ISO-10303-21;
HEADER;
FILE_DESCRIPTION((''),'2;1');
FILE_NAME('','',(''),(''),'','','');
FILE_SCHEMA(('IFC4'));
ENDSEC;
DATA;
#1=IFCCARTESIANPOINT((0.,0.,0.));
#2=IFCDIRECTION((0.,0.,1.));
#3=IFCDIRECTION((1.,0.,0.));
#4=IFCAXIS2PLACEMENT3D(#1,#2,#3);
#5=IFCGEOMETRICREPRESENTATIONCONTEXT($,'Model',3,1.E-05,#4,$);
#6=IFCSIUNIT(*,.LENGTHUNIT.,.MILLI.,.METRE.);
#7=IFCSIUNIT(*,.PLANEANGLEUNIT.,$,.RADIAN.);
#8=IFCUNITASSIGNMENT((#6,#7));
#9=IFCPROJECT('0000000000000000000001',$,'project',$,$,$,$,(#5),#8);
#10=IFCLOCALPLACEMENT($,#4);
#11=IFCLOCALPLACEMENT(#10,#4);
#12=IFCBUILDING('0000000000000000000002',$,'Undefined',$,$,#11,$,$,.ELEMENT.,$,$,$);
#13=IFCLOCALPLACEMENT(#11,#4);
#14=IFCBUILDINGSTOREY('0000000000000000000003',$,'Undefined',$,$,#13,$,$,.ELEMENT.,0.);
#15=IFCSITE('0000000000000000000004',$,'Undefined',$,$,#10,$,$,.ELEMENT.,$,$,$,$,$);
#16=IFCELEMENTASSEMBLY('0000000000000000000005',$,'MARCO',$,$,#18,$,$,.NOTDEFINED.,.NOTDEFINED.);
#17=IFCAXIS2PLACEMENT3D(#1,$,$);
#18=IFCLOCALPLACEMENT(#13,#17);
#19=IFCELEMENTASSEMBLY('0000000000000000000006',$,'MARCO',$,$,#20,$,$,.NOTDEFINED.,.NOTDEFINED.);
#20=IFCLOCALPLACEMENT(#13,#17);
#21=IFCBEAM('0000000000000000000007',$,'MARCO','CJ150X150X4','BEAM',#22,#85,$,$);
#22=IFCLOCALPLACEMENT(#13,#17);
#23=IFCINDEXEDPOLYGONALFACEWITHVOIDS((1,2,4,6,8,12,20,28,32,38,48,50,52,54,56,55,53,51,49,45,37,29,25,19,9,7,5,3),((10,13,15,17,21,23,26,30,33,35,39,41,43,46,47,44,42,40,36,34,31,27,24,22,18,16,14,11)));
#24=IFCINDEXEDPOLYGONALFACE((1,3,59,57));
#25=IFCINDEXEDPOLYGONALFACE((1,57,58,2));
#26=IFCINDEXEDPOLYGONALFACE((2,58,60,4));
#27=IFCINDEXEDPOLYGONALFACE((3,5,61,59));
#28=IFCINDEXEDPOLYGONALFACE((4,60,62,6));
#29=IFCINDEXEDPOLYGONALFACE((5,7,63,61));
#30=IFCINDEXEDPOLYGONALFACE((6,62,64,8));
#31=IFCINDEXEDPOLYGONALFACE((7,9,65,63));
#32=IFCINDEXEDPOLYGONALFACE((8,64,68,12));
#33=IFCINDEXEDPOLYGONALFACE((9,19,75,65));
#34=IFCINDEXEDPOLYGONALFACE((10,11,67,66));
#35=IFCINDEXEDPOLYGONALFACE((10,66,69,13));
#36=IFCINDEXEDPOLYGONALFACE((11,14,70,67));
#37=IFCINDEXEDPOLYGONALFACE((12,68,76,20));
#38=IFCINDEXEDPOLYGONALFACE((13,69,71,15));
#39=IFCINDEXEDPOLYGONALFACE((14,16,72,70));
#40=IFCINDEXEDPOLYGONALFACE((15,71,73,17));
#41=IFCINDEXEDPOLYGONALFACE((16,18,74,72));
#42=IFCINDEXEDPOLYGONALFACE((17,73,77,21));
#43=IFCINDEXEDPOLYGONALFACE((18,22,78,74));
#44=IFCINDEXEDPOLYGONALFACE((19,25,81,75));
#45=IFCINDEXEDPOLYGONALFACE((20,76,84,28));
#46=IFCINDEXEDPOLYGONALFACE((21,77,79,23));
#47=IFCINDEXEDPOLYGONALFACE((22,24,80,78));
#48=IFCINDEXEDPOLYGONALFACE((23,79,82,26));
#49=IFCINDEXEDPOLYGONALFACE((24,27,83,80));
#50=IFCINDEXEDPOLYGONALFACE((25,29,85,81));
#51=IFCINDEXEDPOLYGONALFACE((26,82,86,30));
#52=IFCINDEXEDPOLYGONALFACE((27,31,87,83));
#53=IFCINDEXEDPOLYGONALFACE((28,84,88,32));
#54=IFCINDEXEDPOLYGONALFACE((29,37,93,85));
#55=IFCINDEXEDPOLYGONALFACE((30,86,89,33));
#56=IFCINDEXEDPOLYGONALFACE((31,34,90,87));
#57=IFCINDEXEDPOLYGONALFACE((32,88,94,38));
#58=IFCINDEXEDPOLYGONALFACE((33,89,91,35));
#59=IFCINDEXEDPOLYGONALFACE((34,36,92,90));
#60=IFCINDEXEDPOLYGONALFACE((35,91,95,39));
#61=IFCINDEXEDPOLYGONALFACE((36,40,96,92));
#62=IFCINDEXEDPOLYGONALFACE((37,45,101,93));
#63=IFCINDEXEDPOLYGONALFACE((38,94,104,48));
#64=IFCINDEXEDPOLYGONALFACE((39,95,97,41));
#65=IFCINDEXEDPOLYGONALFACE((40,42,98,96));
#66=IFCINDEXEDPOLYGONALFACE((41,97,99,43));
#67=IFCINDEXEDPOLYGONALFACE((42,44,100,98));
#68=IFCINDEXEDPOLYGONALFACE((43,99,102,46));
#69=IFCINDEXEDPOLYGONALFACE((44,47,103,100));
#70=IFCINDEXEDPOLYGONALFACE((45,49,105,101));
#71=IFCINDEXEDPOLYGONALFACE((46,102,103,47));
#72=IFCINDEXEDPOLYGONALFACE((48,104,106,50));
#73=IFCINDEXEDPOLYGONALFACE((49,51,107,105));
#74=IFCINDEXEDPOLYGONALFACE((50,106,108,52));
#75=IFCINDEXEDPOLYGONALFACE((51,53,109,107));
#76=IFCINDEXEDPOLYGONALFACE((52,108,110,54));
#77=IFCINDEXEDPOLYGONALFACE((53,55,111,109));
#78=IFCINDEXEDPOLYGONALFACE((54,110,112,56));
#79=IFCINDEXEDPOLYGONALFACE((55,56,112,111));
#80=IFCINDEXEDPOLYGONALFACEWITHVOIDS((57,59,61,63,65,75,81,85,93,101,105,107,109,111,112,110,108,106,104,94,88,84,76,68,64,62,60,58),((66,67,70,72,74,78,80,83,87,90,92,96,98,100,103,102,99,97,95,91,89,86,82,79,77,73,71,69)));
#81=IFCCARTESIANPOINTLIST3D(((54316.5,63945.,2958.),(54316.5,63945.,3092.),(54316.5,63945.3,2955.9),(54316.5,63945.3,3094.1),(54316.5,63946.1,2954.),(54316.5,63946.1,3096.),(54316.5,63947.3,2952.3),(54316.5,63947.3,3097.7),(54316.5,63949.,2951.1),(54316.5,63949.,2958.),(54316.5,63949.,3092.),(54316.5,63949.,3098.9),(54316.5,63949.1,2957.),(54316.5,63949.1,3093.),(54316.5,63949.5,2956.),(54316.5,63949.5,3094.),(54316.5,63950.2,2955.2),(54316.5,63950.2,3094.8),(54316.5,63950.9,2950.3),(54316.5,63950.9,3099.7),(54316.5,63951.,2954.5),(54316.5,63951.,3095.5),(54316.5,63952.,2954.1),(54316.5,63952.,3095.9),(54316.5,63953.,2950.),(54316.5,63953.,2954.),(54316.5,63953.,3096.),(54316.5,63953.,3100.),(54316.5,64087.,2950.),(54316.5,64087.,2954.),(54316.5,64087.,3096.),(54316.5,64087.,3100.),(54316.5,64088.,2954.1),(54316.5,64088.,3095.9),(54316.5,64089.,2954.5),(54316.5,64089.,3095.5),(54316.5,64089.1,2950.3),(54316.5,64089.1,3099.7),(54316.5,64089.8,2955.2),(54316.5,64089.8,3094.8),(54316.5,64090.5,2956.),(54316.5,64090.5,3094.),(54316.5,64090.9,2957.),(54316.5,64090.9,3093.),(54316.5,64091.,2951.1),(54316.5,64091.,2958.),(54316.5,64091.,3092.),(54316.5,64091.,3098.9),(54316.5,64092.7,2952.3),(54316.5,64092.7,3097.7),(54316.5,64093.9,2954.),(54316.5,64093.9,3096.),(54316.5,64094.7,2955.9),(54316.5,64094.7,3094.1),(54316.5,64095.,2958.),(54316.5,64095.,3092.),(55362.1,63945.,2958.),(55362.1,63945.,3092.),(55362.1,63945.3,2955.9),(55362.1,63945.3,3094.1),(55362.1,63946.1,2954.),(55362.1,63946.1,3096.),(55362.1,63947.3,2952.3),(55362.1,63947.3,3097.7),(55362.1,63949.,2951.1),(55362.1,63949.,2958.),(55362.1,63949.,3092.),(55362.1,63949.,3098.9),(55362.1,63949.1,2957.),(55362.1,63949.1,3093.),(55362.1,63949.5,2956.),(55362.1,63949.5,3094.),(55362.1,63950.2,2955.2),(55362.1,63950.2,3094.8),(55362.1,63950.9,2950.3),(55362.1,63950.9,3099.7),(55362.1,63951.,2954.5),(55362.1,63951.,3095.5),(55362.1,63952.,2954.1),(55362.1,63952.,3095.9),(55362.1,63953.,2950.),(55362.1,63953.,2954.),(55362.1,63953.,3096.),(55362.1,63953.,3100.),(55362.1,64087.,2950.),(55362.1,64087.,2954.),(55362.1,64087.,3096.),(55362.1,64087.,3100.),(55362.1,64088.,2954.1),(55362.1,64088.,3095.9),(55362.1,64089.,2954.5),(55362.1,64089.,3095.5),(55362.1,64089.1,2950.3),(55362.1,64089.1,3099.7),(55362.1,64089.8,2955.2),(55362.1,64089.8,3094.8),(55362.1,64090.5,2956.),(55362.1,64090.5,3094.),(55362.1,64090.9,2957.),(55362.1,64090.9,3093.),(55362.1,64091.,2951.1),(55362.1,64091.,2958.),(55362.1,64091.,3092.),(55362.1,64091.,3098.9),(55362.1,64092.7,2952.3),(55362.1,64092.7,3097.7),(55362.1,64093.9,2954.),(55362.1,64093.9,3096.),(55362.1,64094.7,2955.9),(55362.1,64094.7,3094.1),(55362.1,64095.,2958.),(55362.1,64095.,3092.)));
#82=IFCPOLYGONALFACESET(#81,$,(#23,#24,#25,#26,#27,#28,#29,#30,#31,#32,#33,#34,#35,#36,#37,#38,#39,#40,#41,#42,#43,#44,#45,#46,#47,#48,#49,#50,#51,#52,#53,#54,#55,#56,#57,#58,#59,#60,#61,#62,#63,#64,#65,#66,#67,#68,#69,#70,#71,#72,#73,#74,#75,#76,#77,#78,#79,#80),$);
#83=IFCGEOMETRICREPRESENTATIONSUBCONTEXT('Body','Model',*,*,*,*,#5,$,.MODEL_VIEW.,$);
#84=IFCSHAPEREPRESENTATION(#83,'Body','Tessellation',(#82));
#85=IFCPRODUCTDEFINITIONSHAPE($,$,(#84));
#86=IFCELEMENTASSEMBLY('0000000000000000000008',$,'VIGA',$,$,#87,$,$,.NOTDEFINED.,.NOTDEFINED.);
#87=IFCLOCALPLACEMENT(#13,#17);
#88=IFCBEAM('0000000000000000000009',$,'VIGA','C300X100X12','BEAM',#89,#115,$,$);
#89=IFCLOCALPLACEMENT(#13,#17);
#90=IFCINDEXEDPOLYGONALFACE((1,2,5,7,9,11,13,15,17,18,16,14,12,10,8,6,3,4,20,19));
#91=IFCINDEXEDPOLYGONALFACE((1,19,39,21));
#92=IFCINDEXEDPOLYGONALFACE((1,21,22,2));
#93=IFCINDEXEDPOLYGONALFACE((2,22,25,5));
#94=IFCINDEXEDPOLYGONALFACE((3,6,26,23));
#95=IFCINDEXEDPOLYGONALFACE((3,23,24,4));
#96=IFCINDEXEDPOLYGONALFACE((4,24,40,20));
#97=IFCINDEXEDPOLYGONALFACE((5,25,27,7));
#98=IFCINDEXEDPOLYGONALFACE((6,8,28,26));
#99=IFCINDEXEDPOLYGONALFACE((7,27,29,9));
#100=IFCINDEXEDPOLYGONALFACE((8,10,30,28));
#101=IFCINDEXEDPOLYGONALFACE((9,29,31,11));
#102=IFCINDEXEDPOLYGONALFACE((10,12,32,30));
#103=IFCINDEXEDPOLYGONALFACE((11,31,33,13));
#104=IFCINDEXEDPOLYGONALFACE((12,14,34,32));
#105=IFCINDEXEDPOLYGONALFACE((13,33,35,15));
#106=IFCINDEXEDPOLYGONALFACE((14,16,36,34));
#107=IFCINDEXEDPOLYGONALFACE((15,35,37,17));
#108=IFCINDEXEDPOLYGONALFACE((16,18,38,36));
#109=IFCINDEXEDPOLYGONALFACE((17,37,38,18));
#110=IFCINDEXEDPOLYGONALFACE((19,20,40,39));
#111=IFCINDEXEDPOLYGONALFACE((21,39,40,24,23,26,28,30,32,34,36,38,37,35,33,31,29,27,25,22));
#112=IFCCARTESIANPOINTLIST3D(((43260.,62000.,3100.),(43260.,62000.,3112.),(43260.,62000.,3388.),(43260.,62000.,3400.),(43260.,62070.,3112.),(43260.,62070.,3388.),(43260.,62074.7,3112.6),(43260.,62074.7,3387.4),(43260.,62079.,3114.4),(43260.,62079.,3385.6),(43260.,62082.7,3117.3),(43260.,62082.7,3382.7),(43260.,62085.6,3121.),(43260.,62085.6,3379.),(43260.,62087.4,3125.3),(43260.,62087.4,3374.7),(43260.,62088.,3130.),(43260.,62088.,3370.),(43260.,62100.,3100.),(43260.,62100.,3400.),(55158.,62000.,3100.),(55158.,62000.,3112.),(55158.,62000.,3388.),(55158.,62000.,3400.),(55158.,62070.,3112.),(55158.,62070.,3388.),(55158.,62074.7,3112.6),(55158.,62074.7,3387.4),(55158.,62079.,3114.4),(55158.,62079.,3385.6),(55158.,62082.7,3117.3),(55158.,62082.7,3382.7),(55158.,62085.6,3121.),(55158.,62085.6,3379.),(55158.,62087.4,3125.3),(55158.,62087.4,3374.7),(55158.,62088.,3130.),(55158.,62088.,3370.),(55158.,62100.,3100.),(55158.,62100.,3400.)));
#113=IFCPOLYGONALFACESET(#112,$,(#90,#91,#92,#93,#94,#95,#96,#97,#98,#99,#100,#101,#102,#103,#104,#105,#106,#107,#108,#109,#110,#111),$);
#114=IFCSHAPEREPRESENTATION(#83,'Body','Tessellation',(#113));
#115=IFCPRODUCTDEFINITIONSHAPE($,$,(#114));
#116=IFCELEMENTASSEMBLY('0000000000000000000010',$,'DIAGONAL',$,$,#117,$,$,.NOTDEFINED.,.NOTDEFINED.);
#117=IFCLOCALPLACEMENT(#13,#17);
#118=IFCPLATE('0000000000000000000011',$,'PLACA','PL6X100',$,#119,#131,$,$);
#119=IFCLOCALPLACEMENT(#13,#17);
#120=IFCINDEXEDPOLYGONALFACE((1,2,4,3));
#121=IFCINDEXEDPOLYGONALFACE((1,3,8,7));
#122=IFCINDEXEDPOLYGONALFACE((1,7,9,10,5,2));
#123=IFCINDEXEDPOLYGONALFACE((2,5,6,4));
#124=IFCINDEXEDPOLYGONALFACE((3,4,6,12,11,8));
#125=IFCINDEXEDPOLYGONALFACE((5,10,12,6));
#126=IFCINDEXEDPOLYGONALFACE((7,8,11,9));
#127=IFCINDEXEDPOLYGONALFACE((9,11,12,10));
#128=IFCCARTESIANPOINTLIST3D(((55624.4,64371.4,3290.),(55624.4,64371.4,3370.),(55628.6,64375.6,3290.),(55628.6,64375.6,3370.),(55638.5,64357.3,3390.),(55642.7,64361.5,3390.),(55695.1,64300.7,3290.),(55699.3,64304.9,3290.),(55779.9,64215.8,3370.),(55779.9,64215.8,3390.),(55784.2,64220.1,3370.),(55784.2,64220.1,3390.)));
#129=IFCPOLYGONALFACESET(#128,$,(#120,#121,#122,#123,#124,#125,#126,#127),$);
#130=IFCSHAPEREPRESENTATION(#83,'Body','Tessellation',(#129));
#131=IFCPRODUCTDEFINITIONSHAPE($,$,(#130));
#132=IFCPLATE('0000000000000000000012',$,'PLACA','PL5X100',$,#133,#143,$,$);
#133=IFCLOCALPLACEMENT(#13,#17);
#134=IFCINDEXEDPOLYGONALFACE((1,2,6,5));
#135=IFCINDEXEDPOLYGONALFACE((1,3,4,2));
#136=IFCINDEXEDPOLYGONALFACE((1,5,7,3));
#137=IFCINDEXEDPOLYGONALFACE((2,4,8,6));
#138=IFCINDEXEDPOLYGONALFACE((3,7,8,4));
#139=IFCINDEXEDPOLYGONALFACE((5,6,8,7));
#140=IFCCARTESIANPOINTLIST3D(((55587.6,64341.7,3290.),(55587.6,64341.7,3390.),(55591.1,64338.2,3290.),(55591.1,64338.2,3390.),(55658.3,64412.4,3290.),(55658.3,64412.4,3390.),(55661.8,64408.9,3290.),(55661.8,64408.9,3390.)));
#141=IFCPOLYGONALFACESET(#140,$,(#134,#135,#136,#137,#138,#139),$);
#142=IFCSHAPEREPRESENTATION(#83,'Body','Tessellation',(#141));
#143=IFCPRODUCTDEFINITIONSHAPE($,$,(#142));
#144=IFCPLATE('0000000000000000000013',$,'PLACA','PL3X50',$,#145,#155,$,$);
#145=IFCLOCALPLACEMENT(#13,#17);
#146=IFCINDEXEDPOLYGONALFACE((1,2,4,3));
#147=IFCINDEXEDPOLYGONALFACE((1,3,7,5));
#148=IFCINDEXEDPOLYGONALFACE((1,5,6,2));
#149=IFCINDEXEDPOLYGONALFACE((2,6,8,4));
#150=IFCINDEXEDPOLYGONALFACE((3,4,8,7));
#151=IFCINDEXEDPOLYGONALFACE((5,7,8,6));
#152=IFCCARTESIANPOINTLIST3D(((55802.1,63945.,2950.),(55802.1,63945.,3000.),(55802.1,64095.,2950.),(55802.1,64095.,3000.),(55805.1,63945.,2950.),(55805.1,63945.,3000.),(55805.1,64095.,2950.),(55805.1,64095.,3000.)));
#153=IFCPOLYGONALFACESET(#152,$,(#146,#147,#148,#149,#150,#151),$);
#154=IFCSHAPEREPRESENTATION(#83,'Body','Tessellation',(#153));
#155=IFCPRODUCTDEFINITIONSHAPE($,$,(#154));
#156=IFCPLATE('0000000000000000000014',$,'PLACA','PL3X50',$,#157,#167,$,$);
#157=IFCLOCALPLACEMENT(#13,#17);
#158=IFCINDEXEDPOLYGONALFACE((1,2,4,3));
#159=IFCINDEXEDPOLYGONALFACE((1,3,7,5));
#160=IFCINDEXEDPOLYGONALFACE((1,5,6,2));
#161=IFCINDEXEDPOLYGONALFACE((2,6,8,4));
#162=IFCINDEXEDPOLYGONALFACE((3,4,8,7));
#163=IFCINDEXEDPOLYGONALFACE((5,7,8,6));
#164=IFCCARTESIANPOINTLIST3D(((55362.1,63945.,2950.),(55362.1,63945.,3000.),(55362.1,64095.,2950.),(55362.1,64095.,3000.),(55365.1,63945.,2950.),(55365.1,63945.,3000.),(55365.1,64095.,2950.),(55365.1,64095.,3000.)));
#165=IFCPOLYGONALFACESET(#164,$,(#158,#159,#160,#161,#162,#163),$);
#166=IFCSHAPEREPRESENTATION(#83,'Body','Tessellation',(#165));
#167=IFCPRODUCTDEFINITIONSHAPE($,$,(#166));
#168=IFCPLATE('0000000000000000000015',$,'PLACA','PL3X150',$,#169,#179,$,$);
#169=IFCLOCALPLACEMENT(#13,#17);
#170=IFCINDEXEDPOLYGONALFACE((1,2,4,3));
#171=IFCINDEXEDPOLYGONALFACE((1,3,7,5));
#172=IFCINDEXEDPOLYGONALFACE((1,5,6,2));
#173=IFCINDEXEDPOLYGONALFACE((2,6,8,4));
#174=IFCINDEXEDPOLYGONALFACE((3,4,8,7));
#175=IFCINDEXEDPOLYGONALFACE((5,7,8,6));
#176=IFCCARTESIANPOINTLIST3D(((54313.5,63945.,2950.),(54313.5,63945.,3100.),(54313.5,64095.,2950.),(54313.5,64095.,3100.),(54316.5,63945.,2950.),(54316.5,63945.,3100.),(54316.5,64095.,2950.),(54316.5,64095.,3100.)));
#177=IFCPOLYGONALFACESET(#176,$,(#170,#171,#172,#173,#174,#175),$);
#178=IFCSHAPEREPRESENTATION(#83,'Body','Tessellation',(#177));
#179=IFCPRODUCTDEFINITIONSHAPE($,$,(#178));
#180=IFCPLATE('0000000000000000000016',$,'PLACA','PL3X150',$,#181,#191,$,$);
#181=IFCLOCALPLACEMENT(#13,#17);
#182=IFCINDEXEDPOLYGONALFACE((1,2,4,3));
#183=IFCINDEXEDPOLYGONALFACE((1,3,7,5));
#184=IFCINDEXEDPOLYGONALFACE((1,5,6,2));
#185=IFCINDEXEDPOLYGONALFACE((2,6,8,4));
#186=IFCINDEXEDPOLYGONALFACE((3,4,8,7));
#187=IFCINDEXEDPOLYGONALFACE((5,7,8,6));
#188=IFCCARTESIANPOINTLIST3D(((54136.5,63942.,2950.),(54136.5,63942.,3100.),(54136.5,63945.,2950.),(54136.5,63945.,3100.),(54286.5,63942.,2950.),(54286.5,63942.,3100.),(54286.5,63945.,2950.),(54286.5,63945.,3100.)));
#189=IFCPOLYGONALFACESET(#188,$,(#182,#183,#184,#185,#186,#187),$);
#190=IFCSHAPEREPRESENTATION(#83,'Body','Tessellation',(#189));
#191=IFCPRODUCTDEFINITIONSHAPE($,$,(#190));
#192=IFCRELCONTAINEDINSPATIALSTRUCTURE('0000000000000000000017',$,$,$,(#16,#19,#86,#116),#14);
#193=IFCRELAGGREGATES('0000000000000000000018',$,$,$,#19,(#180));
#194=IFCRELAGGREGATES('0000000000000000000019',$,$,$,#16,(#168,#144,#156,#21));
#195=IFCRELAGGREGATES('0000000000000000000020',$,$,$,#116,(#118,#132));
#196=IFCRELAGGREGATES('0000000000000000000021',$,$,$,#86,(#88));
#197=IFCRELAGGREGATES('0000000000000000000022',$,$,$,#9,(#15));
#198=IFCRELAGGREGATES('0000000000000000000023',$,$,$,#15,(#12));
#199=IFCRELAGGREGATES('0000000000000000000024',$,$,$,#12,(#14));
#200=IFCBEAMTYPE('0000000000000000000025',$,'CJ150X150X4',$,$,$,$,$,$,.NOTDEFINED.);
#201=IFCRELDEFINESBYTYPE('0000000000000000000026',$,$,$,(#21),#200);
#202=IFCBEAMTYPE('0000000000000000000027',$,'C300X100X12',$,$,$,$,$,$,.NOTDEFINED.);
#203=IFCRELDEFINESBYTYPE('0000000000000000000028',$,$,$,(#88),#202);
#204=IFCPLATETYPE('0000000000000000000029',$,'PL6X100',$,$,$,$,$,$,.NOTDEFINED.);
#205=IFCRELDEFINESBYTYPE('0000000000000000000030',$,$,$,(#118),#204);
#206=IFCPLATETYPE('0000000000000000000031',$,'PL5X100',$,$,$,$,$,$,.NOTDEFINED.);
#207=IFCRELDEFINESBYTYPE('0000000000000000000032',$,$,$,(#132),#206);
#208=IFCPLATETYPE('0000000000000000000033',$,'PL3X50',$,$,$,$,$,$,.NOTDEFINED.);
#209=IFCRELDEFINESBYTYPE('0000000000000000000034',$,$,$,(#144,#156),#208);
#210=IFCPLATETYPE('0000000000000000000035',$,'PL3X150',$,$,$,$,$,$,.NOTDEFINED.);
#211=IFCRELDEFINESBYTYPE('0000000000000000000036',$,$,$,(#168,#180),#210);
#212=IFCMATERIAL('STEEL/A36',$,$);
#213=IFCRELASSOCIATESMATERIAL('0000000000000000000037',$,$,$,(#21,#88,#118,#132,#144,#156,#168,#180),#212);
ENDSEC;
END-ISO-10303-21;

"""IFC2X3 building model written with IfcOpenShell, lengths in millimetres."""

from ifc_helpers import new_model, si_unit, frame, origin_with_axes, origin_2d_with_axis, place, context, subcontext, project, spatial, polyline, hollow_rectangle, u_section, outline, extrude, clip, halfspace, material, type_object, element, aggregate, save


model = new_model("IFC2X3")

# Units and contexts
model_context = context("Model", 3, precision=1e-05, world=origin_with_axes())
body_context = subcontext(model_context, "Body", "Model", "MODEL_VIEW")
ifc_project = project(units=[si_unit("LENGTHUNIT", "METRE", prefix="MILLI"), si_unit("PLANEANGLEUNIT", "RADIAN")], contexts=[model_context])

# Site, building, storey
site_placement = place(None, origin_with_axes())
site = spatial("IfcSite", under=ifc_project, at=site_placement, Name="Undefined", CompositionType="ELEMENT")
building_placement = place(site_placement, origin_with_axes())
building = spatial("IfcBuilding", under=site, at=building_placement, Name="Undefined", CompositionType="ELEMENT")
storey_placement = place(building_placement, origin_with_axes())
storey = spatial("IfcBuildingStorey", under=building, at=storey_placement, Name="Undefined", CompositionType="ELEMENT", Elevation=0.0)

# Element assemblies
assembly_1_placement = place(storey_placement, origin_with_axes())
assembly_1 = element("IfcElementAssembly", 1, at=assembly_1_placement, inside=storey, Name="MARCO", AssemblyPlace="NOTDEFINED", PredefinedType="NOTDEFINED")
ifc_material_1 = material(Name="STEEL/A36")
assembly_2_placement = place(storey_placement, origin_with_axes())
assembly_2 = element("IfcElementAssembly", 2, at=assembly_2_placement, inside=storey, Name="MARCO", AssemblyPlace="NOTDEFINED", PredefinedType="NOTDEFINED")
beam_type_1 = type_object("IfcBeamType", Name="CJ150X150X4", PredefinedType="NOTDEFINED")

# Beam
beam_1_placement = place(assembly_1_placement, frame((54316.5, 64020.0, 3025.0), z_axis=(0.0, 0.0, 1.0), x_axis=(1.0, 0.0, 0.0)))
beam_1 = element("IfcBeam", 3, at=beam_1_placement, type_object=beam_type_1, material=ifc_material_1, Name="MARCO", Description="CJ150X150X4", ObjectType="BEAM", context=body_context, shape_type="SweptSolid", body=[
    extrude(hollow_rectangle(XDim=150.0, YDim=150.0, WallThickness=4.0, InnerFilletRadius=4.0, OuterFilletRadius=8.0, at=origin_2d_with_axis()), frame((1045.6, 0.0, 0.0), z_axis=(-1.0, 0.0, 0.0), x_axis=(0.0, -1.0, 0.0)), (0.0, 0.0, 1.0), 1045.5),
])

# Element assembly, beam
assembly_3_placement = place(storey_placement, origin_with_axes())
assembly_3 = element("IfcElementAssembly", 4, at=assembly_3_placement, inside=storey, Name="VIGA", AssemblyPlace="NOTDEFINED", PredefinedType="NOTDEFINED")
beam_type_2 = type_object("IfcBeamType", Name="C300X100X12", PredefinedType="NOTDEFINED")
beam_2_placement = place(assembly_3_placement, frame((55180.0, 62050.0, 3250.0), z_axis=(0.0, 0.0, -1.0), x_axis=(-1.0, 0.0, 0.0)))
beam_2 = element("IfcBeam", 5, at=beam_2_placement, type_object=beam_type_2, material=ifc_material_1, Name="VIGA", Description="C300X100X12", ObjectType="BEAM", context=body_context, shape_type="Clipping", body=[
    clip(extrude(u_section(Depth=300.0, FlangeWidth=100.0, WebThickness=12.0, FlangeThickness=12.0, FilletRadius=18.0, at=origin_2d_with_axis()), frame((11920.0, 0.0, 0.0), z_axis=(-1.0, 0.0, 0.0), x_axis=(0.0, -1.0, 0.0)), (0.0, 0.0, 1.0), 11920.0), halfspace(frame((22.0, 0.0, -250.0), z_axis=(-1.0, 0.0, 0.0), x_axis=(0.0, 1.0, 0.0)), False)),
])

# Element assembly, plates
assembly_4_placement = place(storey_placement, origin_with_axes())
assembly_4 = element("IfcElementAssembly", 6, at=assembly_4_placement, inside=storey, Name="DIAGONAL", AssemblyPlace="NOTDEFINED", PredefinedType="NOTDEFINED")
plate_type_1 = type_object("IfcPlateType", Name="PL6X100", PredefinedType="NOTDEFINED")
plate_1_placement = place(assembly_4_placement, frame((55782.0, 64218.0, 3290.0), z_axis=(0.707107, 0.707107, 0.0), x_axis=(-0.707107, 0.707107, 0.0)))
plate_1 = element("IfcPlate", 7, at=plate_1_placement, type_object=plate_type_1, material=ifc_material_1, Name="PLACA", Description="PL6X100", context=body_context, shape_type="SweptSolid", body=[
    extrude(outline(polyline([(0.0, 80.0), (120.0, 0.0), (220.0, 0.0), (220.0, 80.0), (200.0, 100.0), (0.0, 100.0), (0.0, 80.0)])), frame((0.0, 0.0, -3.0), z_axis=(0.0, 0.0, 1.0), x_axis=(1.0, 0.0, 0.0)), (0.0, 0.0, 1.0), 6.0),
])
plate_type_2 = type_object("IfcPlateType", Name="PL5X100", PredefinedType="NOTDEFINED")
plate_2_placement = place(assembly_4_placement, frame((55660.1, 64410.6, 3390.0), z_axis=(-0.707107, 0.707107, 0.0), x_axis=(0.0, 0.0, -1.0)))
plate_2 = element("IfcPlate", 8, at=plate_2_placement, type_object=plate_type_2, material=ifc_material_1, Name="PLACA", Description="PL5X100", context=body_context, shape_type="SweptSolid", body=[
    extrude(outline(polyline([(0.0, 0.0), (100.0, 0.0), (100.0, 100.0), (0.0, 100.0), (0.0, 0.0)])), frame((0.0, 0.0, -2.5), z_axis=(0.0, 0.0, 1.0), x_axis=(1.0, 0.0, 0.0)), (0.0, 0.0, 1.0), 5.0),
])

# Plates
plate_type_3 = type_object("IfcPlateType", Name="PL3X50", PredefinedType="NOTDEFINED")
plate_3_placement = place(assembly_1_placement, frame((55803.6, 63945.0, 2950.0), z_axis=(-1.0, 0.0, 0.0), x_axis=(0.0, 0.0, 1.0)))
plate_3 = element("IfcPlate", 9, at=plate_3_placement, type_object=plate_type_3, material=ifc_material_1, Name="PLACA", Description="PL3X50", context=body_context, shape_type="SweptSolid", body=[
    extrude(outline(polyline([(0.0, 0.0), (50.0, 0.0), (50.0, 150.0), (0.0, 150.0), (0.0, 0.0)])), frame((0.0, 0.0, -1.5), z_axis=(0.0, 0.0, 1.0), x_axis=(1.0, 0.0, 0.0)), (0.0, 0.0, 1.0), 3.0),
])
plate_4_placement = place(assembly_1_placement, frame((55363.6, 63945.0, 3000.0), z_axis=(1.0, 0.0, 0.0), x_axis=(0.0, 0.0, -1.0)))
plate_4 = element("IfcPlate", 10, at=plate_4_placement, type_object=plate_type_3, material=ifc_material_1, Name="PLACA", Description="PL3X50", context=body_context, shape_type="SweptSolid", body=[
    extrude(outline(polyline([(0.0, 0.0), (50.0, 0.0), (50.0, 150.0), (0.0, 150.0), (0.0, 0.0)])), frame((0.0, 0.0, -1.5), z_axis=(0.0, 0.0, 1.0), x_axis=(1.0, 0.0, 0.0)), (0.0, 0.0, 1.0), 3.0),
])
plate_type_4 = type_object("IfcPlateType", Name="PL3X150", PredefinedType="NOTDEFINED")
plate_5_placement = place(assembly_1_placement, frame((54315.0, 63945.0, 2950.0), z_axis=(1.0, 0.0, 0.0), x_axis=(0.0, 1.0, 0.0)))
plate_5 = element("IfcPlate", 11, at=plate_5_placement, type_object=plate_type_4, material=ifc_material_1, Name="PLACA", Description="PL3X150", context=body_context, shape_type="SweptSolid", body=[
    extrude(outline(polyline([(0.0, 0.0), (150.0, 0.0), (150.0, 150.0), (0.0, 150.0), (0.0, 0.0)])), frame((0.0, 0.0, -1.5), z_axis=(0.0, 0.0, 1.0), x_axis=(1.0, 0.0, 0.0)), (0.0, 0.0, 1.0), 3.0),
])
plate_6_placement = place(assembly_2_placement, frame((54286.5, 63943.5, 2950.0), z_axis=(0.0, 1.0, 0.0), x_axis=(-1.0, 0.0, 0.0)))
plate_6 = element("IfcPlate", 12, at=plate_6_placement, type_object=plate_type_4, material=ifc_material_1, Name="PLACA", Description="PL3X150", context=body_context, shape_type="SweptSolid", body=[
    extrude(outline(polyline([(0.0, 0.0), (150.0, 0.0), (150.0, 150.0), (0.0, 150.0), (0.0, 0.0)])), frame((0.0, 0.0, -1.5), z_axis=(0.0, 0.0, 1.0), x_axis=(1.0, 0.0, 0.0)), (0.0, 0.0, 1.0), 3.0),
])
aggregate(assembly_2, [plate_6])
aggregate(assembly_1, [plate_5, plate_3, plate_4, beam_1])

aggregate(assembly_4, [plate_1, plate_2])
aggregate(assembly_3, [beam_2])

save(model, "model.ifc")
